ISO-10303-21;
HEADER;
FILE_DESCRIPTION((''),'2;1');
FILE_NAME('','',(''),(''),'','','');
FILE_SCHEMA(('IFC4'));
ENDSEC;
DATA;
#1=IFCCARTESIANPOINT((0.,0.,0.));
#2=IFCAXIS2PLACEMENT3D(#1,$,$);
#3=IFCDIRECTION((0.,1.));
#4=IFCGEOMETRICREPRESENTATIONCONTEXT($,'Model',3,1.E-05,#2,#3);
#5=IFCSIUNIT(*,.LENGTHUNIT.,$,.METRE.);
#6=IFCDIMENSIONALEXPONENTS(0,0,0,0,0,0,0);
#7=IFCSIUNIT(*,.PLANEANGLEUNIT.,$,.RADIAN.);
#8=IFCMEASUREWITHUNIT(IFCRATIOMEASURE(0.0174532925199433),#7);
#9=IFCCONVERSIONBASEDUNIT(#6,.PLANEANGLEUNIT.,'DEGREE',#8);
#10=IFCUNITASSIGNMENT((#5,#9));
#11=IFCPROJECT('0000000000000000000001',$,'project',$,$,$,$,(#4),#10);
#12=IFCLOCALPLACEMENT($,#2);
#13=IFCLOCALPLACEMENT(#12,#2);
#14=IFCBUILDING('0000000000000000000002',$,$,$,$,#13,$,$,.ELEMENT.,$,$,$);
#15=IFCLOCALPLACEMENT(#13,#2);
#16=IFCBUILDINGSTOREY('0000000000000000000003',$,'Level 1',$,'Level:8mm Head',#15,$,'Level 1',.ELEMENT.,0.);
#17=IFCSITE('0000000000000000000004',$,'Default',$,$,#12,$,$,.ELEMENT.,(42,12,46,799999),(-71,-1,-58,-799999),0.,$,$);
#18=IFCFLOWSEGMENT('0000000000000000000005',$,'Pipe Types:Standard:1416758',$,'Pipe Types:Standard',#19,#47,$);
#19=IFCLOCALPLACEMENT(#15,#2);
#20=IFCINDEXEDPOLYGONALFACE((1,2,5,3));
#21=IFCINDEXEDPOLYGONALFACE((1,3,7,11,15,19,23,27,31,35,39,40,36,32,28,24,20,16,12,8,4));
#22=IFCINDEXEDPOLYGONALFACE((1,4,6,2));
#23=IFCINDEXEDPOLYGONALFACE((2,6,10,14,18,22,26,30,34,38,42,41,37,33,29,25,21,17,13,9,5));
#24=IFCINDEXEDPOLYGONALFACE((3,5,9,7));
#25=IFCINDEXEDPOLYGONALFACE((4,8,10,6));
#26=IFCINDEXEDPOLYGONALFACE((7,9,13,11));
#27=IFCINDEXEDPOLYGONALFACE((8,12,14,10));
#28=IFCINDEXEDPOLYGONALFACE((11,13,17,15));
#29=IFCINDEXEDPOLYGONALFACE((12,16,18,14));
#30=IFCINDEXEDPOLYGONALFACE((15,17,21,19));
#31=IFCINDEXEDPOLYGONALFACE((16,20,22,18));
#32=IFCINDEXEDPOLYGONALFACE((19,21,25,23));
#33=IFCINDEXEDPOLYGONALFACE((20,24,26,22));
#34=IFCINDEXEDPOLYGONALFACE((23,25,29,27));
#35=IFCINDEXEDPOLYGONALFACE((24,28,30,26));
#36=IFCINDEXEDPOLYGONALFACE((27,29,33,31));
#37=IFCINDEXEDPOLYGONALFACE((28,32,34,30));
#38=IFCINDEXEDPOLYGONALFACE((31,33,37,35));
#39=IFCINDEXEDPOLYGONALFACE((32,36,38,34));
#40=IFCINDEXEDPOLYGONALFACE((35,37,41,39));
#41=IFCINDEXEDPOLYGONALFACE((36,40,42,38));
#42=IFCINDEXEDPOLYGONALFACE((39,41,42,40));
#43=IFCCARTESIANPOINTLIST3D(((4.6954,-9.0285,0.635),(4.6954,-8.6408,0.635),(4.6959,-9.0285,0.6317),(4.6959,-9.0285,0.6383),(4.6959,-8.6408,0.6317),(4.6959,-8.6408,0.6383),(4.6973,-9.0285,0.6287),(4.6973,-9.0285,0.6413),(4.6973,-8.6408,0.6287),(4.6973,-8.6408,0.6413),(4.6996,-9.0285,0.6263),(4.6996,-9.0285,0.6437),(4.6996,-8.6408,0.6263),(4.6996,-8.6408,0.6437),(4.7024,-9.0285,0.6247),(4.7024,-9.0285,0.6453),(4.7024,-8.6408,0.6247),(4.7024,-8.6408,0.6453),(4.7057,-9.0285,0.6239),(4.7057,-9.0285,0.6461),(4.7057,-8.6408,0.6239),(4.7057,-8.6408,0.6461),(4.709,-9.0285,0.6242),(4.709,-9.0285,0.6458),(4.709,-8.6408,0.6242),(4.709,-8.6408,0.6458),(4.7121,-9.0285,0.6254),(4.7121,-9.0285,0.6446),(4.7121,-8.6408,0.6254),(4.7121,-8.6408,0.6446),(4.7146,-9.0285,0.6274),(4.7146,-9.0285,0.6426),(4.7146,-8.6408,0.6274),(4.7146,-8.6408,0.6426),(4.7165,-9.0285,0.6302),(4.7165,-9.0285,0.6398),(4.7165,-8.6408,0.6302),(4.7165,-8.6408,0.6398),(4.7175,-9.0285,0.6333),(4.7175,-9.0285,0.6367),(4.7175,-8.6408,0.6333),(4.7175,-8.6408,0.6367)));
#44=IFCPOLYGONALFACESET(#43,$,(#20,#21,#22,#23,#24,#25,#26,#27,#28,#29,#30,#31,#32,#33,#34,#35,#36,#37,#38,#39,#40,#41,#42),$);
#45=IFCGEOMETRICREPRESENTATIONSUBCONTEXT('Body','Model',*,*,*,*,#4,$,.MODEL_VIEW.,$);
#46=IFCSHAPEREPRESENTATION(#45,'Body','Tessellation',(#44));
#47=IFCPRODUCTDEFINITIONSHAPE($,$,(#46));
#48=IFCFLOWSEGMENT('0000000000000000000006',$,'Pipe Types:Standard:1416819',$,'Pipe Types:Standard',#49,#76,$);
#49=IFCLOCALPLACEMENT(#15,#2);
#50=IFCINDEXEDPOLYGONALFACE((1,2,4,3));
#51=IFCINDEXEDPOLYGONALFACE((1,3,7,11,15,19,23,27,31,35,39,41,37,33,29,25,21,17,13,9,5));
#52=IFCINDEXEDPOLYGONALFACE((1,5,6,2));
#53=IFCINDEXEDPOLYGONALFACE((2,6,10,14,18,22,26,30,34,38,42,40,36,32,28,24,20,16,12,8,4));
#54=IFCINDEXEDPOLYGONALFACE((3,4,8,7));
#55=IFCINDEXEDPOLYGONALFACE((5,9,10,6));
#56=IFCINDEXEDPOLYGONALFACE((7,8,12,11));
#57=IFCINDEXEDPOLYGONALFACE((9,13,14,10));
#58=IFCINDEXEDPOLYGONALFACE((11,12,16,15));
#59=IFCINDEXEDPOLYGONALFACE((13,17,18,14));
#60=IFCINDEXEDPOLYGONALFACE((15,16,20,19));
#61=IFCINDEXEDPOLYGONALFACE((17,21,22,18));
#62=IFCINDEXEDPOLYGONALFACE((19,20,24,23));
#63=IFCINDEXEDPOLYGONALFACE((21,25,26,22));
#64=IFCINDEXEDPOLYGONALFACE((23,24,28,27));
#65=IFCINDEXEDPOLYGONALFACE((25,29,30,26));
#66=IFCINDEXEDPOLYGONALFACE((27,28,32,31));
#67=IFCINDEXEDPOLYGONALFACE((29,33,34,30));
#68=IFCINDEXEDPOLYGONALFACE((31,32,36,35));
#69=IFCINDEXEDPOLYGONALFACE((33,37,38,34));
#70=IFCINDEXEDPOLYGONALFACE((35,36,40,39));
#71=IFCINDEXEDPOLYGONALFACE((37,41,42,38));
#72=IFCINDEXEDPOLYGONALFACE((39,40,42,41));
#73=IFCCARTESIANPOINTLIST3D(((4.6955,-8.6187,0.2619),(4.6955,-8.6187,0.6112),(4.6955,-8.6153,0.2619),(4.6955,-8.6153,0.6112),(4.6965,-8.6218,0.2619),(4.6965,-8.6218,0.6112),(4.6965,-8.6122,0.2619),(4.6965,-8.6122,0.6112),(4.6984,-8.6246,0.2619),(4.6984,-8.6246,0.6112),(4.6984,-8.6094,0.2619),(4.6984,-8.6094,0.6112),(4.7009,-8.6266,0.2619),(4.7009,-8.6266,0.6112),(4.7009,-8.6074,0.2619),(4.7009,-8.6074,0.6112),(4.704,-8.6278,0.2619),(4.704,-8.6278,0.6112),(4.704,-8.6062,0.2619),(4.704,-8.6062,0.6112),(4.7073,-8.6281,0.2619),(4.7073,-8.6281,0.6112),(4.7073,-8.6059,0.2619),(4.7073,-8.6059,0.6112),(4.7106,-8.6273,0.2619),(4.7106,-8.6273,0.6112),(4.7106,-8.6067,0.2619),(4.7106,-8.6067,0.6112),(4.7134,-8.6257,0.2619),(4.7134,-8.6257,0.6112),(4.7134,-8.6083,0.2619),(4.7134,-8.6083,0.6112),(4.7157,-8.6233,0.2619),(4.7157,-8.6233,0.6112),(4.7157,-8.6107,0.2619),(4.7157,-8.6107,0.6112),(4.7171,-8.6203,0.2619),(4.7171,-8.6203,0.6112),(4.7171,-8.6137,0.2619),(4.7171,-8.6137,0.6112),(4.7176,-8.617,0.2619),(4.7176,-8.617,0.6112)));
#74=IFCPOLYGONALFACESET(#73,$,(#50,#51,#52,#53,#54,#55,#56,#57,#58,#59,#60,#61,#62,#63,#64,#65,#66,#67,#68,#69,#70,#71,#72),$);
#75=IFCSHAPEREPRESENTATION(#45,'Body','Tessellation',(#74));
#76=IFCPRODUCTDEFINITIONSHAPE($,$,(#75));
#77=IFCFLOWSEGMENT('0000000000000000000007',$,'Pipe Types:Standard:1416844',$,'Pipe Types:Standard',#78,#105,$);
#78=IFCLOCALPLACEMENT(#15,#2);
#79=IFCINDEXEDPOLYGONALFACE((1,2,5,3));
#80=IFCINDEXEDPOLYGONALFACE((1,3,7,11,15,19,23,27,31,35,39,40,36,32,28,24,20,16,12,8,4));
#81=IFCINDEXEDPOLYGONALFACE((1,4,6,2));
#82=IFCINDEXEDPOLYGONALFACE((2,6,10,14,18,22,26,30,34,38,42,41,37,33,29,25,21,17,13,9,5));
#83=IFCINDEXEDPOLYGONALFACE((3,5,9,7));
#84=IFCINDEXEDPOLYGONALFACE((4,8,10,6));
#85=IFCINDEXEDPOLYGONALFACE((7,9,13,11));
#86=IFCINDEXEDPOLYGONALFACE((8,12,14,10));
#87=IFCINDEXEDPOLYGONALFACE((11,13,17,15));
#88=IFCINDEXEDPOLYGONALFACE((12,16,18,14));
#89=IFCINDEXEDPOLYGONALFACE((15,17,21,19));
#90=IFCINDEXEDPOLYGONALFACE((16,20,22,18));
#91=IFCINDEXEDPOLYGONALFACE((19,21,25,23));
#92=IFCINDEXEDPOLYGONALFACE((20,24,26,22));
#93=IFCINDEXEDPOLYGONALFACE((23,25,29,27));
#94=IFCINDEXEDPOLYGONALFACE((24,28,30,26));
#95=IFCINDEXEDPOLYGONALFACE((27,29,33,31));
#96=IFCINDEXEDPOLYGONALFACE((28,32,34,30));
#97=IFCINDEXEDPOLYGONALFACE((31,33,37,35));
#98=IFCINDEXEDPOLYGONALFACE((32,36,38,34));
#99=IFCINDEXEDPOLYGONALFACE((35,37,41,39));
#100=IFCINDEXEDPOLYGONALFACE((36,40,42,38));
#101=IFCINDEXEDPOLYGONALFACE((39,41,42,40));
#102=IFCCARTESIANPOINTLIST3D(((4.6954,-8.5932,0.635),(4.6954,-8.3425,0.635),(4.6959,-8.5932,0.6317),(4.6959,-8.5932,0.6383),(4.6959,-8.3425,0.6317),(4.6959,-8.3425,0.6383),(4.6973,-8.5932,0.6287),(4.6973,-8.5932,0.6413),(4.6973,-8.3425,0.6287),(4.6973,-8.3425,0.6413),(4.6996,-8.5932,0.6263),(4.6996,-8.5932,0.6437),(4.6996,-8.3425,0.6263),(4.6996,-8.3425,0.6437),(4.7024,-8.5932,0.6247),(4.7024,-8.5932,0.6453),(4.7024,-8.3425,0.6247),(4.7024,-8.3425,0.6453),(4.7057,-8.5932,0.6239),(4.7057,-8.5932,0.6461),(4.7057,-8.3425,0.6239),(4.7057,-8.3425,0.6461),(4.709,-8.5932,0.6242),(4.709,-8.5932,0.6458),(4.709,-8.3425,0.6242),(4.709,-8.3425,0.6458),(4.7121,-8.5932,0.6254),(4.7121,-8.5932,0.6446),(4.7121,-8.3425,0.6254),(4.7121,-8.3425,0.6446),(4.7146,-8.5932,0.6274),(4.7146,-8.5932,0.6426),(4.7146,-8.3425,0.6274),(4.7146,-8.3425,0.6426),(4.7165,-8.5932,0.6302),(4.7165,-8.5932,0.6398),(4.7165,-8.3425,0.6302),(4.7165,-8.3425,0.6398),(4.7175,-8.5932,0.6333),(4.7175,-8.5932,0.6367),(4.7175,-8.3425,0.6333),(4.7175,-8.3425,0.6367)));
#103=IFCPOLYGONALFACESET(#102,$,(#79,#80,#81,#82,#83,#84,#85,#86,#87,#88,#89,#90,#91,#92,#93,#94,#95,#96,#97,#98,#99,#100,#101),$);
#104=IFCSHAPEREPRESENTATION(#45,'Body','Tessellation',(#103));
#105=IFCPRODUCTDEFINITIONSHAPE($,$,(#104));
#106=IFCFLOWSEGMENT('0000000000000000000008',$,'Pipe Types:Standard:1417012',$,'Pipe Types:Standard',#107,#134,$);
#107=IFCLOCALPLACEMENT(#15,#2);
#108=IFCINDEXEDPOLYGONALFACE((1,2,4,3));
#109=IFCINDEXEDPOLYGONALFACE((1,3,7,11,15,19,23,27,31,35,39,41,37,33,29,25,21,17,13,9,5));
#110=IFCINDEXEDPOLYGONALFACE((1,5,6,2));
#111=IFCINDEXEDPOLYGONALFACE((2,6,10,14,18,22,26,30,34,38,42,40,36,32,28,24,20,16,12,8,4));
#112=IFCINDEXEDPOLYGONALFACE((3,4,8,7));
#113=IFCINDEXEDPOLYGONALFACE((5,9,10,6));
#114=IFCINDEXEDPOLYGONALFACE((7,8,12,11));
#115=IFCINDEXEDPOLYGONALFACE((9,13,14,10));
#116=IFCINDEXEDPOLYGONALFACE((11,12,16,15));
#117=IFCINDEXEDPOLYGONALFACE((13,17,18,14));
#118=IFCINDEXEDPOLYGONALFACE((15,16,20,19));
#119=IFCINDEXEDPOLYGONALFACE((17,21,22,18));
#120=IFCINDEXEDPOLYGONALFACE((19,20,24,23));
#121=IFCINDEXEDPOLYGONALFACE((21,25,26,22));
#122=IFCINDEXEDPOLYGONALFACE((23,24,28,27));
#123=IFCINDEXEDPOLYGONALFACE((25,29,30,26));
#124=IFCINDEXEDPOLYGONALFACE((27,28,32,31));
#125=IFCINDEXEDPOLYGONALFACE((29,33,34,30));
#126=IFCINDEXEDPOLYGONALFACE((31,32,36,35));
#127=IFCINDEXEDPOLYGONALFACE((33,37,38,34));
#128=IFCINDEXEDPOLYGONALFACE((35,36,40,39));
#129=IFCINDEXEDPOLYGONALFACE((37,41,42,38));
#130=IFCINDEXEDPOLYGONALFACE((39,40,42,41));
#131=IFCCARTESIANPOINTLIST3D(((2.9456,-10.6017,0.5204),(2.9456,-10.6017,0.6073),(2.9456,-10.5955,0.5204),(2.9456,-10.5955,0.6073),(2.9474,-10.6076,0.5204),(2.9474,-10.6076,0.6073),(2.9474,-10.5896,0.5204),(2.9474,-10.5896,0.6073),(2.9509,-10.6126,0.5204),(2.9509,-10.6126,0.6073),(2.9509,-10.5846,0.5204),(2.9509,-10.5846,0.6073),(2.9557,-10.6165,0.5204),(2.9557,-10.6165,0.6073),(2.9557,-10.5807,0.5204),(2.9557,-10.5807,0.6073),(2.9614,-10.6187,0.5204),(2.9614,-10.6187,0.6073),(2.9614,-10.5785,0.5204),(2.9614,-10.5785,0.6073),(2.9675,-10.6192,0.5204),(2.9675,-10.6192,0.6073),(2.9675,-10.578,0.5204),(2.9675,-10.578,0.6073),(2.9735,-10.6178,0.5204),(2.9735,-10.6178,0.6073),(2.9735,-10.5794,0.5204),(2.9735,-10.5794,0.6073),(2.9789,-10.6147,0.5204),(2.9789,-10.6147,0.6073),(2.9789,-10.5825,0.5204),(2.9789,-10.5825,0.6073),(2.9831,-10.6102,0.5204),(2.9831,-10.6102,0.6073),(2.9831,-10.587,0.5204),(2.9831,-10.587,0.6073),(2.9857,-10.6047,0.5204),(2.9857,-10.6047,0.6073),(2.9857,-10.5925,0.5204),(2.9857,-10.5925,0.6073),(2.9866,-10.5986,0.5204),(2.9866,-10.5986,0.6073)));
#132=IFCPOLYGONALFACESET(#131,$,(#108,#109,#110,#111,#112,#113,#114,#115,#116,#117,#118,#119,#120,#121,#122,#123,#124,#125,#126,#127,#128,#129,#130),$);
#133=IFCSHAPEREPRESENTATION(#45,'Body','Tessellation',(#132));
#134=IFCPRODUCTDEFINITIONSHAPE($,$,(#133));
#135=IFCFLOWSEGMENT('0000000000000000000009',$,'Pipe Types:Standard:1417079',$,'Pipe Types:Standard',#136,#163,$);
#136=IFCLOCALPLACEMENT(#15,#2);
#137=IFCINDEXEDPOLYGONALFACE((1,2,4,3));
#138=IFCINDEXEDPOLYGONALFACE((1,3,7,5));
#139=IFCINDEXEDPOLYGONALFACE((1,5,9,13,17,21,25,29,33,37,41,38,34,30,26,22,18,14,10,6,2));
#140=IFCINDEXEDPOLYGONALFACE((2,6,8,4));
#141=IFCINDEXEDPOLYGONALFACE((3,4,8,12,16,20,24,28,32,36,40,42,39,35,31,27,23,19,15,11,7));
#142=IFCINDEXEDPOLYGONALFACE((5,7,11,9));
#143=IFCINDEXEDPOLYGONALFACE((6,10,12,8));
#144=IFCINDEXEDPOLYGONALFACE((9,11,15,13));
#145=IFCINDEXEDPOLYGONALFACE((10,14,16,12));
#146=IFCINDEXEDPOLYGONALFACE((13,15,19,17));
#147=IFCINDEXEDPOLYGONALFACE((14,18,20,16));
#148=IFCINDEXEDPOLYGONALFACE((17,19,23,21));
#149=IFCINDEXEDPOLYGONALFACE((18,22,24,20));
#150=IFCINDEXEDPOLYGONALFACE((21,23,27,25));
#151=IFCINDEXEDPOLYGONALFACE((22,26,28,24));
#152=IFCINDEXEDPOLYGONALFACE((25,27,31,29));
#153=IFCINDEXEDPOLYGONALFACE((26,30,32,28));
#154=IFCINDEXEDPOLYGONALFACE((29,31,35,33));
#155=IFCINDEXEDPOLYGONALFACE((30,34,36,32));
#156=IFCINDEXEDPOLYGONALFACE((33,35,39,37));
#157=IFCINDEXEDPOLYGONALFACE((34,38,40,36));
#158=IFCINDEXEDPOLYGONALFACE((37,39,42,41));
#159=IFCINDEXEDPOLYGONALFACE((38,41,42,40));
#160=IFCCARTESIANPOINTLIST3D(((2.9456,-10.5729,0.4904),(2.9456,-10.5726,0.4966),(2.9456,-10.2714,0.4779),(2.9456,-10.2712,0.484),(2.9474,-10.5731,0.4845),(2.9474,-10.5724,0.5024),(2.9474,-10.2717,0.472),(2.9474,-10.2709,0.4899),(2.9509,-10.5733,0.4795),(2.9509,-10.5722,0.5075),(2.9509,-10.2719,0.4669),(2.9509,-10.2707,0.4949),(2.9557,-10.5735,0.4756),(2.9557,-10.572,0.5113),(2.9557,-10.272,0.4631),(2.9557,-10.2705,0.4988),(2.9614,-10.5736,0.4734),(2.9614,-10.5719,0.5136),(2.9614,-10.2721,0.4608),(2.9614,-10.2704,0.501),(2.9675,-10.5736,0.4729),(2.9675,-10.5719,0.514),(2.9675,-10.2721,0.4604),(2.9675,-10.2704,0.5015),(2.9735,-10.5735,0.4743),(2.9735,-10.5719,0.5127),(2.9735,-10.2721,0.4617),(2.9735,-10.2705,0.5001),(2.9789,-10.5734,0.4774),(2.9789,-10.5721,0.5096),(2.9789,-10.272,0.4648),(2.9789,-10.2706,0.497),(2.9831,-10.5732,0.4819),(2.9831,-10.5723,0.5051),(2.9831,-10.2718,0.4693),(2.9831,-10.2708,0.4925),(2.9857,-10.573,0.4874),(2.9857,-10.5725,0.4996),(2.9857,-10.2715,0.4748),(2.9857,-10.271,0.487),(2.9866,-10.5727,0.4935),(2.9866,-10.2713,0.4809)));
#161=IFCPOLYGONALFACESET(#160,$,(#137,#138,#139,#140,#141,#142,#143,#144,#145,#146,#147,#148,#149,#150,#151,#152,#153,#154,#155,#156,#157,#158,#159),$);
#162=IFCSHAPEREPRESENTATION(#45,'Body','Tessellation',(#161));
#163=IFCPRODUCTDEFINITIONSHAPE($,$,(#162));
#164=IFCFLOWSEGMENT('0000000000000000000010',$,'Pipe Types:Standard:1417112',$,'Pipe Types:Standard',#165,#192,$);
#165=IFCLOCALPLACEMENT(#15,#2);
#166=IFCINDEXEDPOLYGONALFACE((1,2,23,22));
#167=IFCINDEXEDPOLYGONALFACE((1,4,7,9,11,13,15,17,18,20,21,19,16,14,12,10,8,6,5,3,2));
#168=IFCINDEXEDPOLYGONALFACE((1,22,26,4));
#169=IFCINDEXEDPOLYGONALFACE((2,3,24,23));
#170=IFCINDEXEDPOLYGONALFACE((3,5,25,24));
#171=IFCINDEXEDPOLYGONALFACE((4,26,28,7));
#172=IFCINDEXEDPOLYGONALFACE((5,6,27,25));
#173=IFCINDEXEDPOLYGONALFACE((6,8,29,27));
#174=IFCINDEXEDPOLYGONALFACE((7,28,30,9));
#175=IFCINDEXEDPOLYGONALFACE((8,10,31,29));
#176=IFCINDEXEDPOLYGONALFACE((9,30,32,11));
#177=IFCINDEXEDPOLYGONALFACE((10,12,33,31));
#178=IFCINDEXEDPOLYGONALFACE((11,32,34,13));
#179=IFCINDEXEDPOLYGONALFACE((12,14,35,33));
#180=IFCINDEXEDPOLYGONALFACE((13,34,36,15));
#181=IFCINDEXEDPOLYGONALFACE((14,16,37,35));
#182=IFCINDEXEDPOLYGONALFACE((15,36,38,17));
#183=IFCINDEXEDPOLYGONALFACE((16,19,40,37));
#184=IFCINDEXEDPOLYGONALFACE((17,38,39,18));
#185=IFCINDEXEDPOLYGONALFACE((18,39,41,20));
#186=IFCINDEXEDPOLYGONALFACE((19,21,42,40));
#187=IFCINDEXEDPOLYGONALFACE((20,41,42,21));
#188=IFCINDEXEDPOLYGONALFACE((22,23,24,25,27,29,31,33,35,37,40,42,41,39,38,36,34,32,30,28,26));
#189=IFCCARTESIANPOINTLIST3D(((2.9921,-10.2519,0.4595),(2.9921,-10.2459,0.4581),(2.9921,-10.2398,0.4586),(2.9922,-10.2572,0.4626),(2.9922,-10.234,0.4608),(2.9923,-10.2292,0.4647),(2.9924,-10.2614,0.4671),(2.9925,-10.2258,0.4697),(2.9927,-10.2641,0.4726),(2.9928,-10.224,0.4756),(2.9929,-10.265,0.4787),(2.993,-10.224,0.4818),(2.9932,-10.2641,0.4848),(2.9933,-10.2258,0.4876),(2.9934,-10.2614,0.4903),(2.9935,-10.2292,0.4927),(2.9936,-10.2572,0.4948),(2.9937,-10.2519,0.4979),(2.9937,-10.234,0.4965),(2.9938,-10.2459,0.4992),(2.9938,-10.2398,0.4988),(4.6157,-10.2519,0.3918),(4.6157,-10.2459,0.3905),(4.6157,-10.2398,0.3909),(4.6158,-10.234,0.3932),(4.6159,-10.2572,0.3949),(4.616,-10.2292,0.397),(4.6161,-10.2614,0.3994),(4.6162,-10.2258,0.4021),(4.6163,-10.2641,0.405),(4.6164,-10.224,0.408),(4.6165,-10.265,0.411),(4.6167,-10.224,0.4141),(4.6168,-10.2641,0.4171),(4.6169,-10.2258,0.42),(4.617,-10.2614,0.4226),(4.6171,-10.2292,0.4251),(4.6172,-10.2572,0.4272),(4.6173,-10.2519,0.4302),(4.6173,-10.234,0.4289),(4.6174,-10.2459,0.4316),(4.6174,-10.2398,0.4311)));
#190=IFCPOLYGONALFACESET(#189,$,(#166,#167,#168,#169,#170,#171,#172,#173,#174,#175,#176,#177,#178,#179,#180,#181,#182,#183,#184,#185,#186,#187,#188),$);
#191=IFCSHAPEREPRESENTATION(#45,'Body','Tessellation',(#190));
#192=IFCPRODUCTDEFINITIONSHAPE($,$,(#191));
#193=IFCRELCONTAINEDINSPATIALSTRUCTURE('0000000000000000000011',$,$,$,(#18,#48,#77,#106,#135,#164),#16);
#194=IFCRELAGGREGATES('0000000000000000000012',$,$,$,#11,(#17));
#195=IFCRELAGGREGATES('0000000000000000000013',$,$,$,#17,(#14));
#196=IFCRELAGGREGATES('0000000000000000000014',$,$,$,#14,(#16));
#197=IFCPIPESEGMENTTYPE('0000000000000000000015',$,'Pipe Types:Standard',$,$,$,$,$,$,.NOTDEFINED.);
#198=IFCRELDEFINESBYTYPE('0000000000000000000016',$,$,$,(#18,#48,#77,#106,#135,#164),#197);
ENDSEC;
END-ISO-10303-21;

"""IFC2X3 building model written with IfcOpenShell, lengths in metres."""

from ifc_helpers import new_model, entity, si_unit, converted_unit, direction, frame, frame_2d, origin, origin_2d_with_axis, place, context, subcontext, project, spatial, circle, extrude, type_object, element, save


model = new_model("IFC2X3")

# Units and contexts
model_context = context("Model", 3, precision=1e-05, world=origin(), true_north=direction((0.0, 1.0)))
body_context = subcontext(model_context, "Body", "Model", "MODEL_VIEW")
ifc_project = project(units=[si_unit("LENGTHUNIT", "METRE"), converted_unit("PLANEANGLEUNIT", "DEGREE", entity("IfcRatioMeasure", 0.0174532925199433), si_unit("PLANEANGLEUNIT", "RADIAN"), dimensions=[0, 0, 0, 0, 0, 0, 0])], contexts=[model_context])

# Site, building, storey
site_placement = place(None, origin())
site = spatial("IfcSite", under=ifc_project, at=site_placement, Name="Default", CompositionType="ELEMENT", RefLatitude=(42, 12, 46, 799999), RefLongitude=(-71, -1, -58, -799999), RefElevation=0.0)
building_placement = place(site_placement, origin())
building = spatial("IfcBuilding", under=site, at=building_placement, CompositionType="ELEMENT")
storey_placement = place(building_placement, origin())
storey = spatial("IfcBuildingStorey", under=building, at=storey_placement, Name="Level 1", ObjectType="Level:8mm Head", LongName="Level 1", CompositionType="ELEMENT", Elevation=0.0)

# Flow segments
pipe_segment_type = type_object("IfcPipeSegmentType", Name="Pipe Types:Standard", PredefinedType="NOTDEFINED")
flow_segment_1_placement = place(storey_placement, origin())
element("IfcFlowSegment", 1, at=flow_segment_1_placement, inside=storey, type_object=pipe_segment_type, Name="Pipe Types:Standard:1416758", ObjectType="Pipe Types:Standard", context=body_context, shape_type="SweptSolid", body=[
    extrude(circle(Radius=0.0111, at=frame_2d((0.0, 0.0), x_axis=(1.0, 0.0))), frame((4.7065, -9.0285, 0.635), z_axis=(0.0, 1.0, 0.0), x_axis=(-1.0, 0.0, 0.0)), (0.0, 0.0, 1.0), 0.3877),
])
flow_segment_2_placement = place(storey_placement, origin())
element("IfcFlowSegment", 2, at=flow_segment_2_placement, inside=storey, type_object=pipe_segment_type, Name="Pipe Types:Standard:1416819", ObjectType="Pipe Types:Standard", context=body_context, shape_type="SweptSolid", body=[
    extrude(circle(Radius=0.0111, at=frame_2d((0.0, 0.0), x_axis=(1.0, 0.0))), frame((4.7065, -8.617, 0.2619)), (0.0, 0.0, 1.0), 0.3493),
])
flow_segment_3_placement = place(storey_placement, origin())
element("IfcFlowSegment", 3, at=flow_segment_3_placement, inside=storey, type_object=pipe_segment_type, Name="Pipe Types:Standard:1416844", ObjectType="Pipe Types:Standard", context=body_context, shape_type="SweptSolid", body=[
    extrude(circle(Radius=0.0111, at=frame_2d((0.0, 0.0), x_axis=(1.0, 0.0))), frame((4.7065, -8.5932, 0.635), z_axis=(0.0, 1.0, 0.0), x_axis=(-1.0, 0.0, 0.0)), (0.0, 0.0, 1.0), 0.2506),
])
flow_segment_4_placement = place(storey_placement, origin())
element("IfcFlowSegment", 4, at=flow_segment_4_placement, inside=storey, type_object=pipe_segment_type, Name="Pipe Types:Standard:1417012", ObjectType="Pipe Types:Standard", context=body_context, shape_type="SweptSolid", body=[
    extrude(circle(Radius=0.0206, at=origin_2d_with_axis()), frame((2.966, -10.5986, 0.5204)), (0.0, 0.0, 1.0), 0.0868),
])
flow_segment_5_placement = place(storey_placement, origin())
element("IfcFlowSegment", 5, at=flow_segment_5_placement, inside=storey, type_object=pipe_segment_type, Name="Pipe Types:Standard:1417079", ObjectType="Pipe Types:Standard", context=body_context, shape_type="SweptSolid", body=[
    extrude(circle(Radius=0.0206, at=frame_2d((0.0, 0.0), x_axis=(1.0, 0.0))), frame((2.966, -10.2713, 0.4809), z_axis=(0.0, -0.999133, 0.041631), x_axis=(1.0, 0.0, 0.0)), (0.0, 0.0, 1.0), 0.3017),
])
flow_segment_6_placement = place(storey_placement, origin())
element("IfcFlowSegment", 6, at=flow_segment_6_placement, inside=storey, type_object=pipe_segment_type, Name="Pipe Types:Standard:1417112", ObjectType="Pipe Types:Standard", context=body_context, shape_type="SweptSolid", body=[
    extrude(circle(Radius=0.0206, at=origin_2d_with_axis()), frame((4.6165, -10.2444, 0.411), z_axis=(-0.999133, 0.0, 0.041631), x_axis=(0.0, -1.0, 0.0)), (0.0, 0.0, 1.0), 1.625),
])

save(model, "model.ifc")
